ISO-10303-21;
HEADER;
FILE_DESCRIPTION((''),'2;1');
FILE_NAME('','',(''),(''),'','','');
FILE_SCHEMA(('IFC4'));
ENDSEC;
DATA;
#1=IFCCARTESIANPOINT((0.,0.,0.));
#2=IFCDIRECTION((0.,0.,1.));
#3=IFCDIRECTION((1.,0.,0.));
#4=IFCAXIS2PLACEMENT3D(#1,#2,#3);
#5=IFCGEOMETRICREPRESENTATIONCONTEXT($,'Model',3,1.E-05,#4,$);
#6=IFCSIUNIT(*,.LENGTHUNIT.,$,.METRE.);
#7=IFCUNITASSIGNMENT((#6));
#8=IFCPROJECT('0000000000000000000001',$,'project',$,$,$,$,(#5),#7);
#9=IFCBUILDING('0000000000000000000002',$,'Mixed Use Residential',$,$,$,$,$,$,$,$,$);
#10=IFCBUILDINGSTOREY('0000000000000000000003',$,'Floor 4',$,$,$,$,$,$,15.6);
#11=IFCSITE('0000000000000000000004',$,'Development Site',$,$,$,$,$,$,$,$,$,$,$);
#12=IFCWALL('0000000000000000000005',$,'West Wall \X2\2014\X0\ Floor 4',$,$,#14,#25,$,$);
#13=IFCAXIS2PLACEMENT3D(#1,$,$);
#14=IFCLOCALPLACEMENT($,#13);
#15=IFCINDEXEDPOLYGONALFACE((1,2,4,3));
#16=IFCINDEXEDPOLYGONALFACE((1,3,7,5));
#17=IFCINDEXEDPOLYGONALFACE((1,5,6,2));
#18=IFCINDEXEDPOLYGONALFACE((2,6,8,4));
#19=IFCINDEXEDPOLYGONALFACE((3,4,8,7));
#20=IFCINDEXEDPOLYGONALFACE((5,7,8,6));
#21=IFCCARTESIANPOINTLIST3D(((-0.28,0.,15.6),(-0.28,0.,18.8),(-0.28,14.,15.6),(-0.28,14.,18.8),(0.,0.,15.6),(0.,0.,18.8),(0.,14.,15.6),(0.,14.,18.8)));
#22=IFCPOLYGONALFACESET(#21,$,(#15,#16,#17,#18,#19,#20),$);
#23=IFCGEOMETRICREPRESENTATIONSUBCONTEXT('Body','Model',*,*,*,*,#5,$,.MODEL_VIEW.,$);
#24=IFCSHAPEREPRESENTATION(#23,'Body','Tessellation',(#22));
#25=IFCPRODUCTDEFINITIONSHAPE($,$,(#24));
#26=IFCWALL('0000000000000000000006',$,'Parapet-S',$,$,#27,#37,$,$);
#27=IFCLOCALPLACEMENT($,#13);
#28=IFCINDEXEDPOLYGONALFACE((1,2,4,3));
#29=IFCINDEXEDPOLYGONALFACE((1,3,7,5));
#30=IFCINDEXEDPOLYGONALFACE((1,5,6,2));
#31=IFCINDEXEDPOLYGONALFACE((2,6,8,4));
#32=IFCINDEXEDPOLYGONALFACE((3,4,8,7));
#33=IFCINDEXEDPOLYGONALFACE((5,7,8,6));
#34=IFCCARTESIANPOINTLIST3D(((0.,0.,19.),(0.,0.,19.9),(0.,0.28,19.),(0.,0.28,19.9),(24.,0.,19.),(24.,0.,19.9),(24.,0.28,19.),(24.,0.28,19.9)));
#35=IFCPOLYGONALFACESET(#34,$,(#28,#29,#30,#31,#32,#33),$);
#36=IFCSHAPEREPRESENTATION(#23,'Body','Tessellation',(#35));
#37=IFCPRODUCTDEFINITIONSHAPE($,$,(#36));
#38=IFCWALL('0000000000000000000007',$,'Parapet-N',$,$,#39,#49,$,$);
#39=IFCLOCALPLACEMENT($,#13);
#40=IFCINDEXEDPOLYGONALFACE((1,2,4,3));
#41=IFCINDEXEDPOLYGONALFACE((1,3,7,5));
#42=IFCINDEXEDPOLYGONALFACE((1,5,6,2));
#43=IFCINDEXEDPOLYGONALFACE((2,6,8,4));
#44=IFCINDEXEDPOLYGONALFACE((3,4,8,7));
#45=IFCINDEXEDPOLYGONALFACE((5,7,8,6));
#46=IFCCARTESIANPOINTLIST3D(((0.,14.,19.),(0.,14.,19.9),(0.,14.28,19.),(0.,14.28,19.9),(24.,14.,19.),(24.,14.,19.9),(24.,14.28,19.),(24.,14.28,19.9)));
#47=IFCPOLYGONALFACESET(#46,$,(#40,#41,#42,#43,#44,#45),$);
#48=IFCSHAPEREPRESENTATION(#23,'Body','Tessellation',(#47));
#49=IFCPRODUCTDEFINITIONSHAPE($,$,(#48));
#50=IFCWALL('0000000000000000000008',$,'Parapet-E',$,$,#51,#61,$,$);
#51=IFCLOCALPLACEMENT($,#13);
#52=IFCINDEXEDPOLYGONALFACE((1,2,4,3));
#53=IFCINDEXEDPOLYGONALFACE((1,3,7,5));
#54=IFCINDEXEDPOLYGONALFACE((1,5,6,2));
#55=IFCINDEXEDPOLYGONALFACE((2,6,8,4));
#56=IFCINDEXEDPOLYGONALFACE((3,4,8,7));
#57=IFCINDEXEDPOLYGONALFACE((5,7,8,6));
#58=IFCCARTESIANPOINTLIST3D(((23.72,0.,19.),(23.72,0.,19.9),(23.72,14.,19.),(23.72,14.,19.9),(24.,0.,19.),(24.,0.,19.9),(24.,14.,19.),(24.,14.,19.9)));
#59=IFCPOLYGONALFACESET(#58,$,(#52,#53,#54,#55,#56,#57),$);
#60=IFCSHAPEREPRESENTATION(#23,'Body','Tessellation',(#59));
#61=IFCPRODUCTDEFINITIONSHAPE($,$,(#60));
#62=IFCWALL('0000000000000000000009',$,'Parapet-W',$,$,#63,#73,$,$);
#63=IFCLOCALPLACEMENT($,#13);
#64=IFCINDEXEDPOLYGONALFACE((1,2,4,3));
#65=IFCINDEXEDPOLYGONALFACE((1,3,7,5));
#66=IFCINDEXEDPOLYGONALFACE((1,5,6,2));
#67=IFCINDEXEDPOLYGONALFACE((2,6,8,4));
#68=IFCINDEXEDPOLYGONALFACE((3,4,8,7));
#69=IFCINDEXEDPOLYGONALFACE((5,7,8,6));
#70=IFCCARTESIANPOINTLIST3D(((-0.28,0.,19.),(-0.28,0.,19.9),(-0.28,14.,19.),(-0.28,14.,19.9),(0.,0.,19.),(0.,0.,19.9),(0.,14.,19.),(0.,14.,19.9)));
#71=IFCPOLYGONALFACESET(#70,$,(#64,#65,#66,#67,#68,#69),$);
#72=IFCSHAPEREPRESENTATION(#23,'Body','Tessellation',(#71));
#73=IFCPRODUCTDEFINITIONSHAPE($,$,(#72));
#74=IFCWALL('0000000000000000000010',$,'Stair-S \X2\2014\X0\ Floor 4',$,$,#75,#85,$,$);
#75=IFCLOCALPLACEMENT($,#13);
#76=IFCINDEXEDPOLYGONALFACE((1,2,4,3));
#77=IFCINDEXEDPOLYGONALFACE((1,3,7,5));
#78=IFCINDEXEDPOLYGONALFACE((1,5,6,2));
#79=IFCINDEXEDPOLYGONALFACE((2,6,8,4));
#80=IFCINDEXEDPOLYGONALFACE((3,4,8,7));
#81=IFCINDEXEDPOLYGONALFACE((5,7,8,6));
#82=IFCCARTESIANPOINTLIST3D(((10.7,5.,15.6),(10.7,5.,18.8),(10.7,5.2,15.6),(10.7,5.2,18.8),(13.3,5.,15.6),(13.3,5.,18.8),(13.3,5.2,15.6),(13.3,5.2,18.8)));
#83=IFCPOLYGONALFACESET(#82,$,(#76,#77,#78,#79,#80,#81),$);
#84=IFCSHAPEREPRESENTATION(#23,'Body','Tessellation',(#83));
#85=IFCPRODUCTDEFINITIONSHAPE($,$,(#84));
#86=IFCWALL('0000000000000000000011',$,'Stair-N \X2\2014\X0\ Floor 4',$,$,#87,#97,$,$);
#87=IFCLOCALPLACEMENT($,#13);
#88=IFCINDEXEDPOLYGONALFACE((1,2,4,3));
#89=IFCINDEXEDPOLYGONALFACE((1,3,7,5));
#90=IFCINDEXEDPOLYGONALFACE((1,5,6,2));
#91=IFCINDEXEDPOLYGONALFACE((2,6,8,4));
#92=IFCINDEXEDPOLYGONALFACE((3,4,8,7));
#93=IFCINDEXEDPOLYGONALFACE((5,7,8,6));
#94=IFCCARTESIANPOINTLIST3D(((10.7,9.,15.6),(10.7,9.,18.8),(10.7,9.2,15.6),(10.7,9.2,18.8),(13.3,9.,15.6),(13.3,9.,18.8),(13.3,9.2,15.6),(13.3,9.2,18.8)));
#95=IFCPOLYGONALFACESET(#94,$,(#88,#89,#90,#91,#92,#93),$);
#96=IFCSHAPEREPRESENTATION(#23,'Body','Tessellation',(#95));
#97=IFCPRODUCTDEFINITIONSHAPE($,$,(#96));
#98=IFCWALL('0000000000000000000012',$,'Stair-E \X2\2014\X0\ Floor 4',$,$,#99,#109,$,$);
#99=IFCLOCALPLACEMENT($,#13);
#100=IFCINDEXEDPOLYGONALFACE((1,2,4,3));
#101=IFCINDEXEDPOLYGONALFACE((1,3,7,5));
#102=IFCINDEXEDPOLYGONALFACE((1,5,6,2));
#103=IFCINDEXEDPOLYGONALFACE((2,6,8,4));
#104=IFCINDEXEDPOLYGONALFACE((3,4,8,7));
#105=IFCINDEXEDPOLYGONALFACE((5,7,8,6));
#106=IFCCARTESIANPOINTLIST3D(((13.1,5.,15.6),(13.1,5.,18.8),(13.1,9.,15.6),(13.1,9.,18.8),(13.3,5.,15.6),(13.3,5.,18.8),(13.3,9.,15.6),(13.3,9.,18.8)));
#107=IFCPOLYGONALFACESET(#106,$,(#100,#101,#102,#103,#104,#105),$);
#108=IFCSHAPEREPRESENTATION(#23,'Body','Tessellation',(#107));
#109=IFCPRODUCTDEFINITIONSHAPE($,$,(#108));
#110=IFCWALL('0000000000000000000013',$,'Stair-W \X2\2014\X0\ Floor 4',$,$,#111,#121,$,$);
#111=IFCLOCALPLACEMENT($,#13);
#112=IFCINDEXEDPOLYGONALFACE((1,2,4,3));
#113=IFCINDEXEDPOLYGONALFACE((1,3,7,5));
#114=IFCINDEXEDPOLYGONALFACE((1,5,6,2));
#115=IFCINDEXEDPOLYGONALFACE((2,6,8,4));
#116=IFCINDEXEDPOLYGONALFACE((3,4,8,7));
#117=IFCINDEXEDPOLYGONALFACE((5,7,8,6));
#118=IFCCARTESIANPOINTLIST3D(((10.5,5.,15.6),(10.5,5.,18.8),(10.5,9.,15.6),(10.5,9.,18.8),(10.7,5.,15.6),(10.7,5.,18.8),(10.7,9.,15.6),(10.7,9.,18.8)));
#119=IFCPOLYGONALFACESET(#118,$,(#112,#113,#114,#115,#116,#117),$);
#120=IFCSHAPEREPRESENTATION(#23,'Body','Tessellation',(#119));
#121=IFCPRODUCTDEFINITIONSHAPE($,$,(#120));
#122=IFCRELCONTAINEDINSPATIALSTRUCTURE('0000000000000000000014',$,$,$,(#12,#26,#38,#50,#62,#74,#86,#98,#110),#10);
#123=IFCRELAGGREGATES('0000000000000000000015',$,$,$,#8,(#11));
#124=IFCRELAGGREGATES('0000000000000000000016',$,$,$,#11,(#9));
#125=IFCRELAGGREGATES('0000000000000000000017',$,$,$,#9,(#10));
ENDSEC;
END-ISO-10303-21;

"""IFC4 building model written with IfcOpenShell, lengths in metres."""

from ifc_helpers import new_model, si_unit, frame, origin_with_axes, place, context, subcontext, project, spatial, indexed_curve, outline, extrude, element, save


model = new_model("IFC4")

# Units and contexts
model_context = context("Model", 3, precision=1e-05, world=origin_with_axes())
body_context = subcontext(model_context, "Body", "Model", "MODEL_VIEW")
ifc_project = project(units=[si_unit("LENGTHUNIT", "METRE")], contexts=[model_context])

# Site, building, storey
site = spatial("IfcSite", under=ifc_project, Name="Development Site")
building = spatial("IfcBuilding", under=site, Name="Mixed Use Residential")
storey = spatial("IfcBuildingStorey", under=building, Name="Floor 4", Elevation=15.6)

# Walls
for number, where, z_axis, x_axis, name in (
    (1, (0.0, 0.0, 15.6), (0.0, 0.0, 1.0), (0.0, 1.0, 0.0), "West Wall — Floor 4"),
):
    element("IfcWall", number, at=place(None, frame(where, z_axis=z_axis, x_axis=x_axis)), inside=storey, Name=name, context=body_context, shape_type="SweptSolid", body=[
        extrude(outline(indexed_curve([(0.0, 0.0), (0.0, 0.28), (14.0, 0.28), (14.0, 0.0), (0.0, 0.0)], self_intersect=False)), origin_with_axes(), (0.0, 0.0, 1.0), 3.2),
    ])
for number, where, z_axis, x_axis, name in (
    (2, (0.0, 0.0, 19.0), (0.0, 0.0, 1.0), (1.0, 0.0, 0.0), "Parapet-S"),
    (3, (0.0, 14.0, 19.0), (0.0, 0.0, 1.0), (1.0, 0.0, 0.0), "Parapet-N"),
):
    element("IfcWall", number, at=place(None, frame(where, z_axis=z_axis, x_axis=x_axis)), inside=storey, Name=name, context=body_context, shape_type="SweptSolid", body=[
        extrude(outline(indexed_curve([(0.0, 0.0), (0.0, 0.28), (24.0, 0.28), (24.0, 0.0), (0.0, 0.0)], self_intersect=False)), origin_with_axes(), (0.0, 0.0, 1.0), 0.9),
    ])
for number, where, z_axis, x_axis, name in (
    (4, (24.0, 0.0, 19.0), (0.0, 0.0, 1.0), (0.0, 1.0, 0.0), "Parapet-E"),
    (5, (0.0, 0.0, 19.0), (0.0, 0.0, 1.0), (0.0, 1.0, 0.0), "Parapet-W"),
):
    element("IfcWall", number, at=place(None, frame(where, z_axis=z_axis, x_axis=x_axis)), inside=storey, Name=name, context=body_context, shape_type="SweptSolid", body=[
        extrude(outline(indexed_curve([(0.0, 0.0), (0.0, 0.28), (14.0, 0.28), (14.0, 0.0), (0.0, 0.0)], self_intersect=False)), origin_with_axes(), (0.0, 0.0, 1.0), 0.9),
    ])
for number, where, z_axis, x_axis, name in (
    (6, (10.7, 5.0, 15.6), (0.0, 0.0, 1.0), (1.0, 0.0, 0.0), "Stair-S — Floor 4"),
    (7, (10.7, 9.0, 15.6), (0.0, 0.0, 1.0), (1.0, 0.0, 0.0), "Stair-N — Floor 4"),
):
    element("IfcWall", number, at=place(None, frame(where, z_axis=z_axis, x_axis=x_axis)), inside=storey, Name=name, context=body_context, shape_type="SweptSolid", body=[
        extrude(outline(indexed_curve([(0.0, 0.0), (0.0, 0.2), (2.6, 0.2), (2.6, 0.0), (0.0, 0.0)], self_intersect=False)), origin_with_axes(), (0.0, 0.0, 1.0), 3.2),
    ])
for number, where, z_axis, x_axis, name in (
    (8, (13.3, 5.0, 15.6), (0.0, 0.0, 1.0), (0.0, 1.0, 0.0), "Stair-E — Floor 4"),
    (9, (10.7, 5.0, 15.6), (0.0, 0.0, 1.0), (0.0, 1.0, 0.0), "Stair-W — Floor 4"),
):
    element("IfcWall", number, at=place(None, frame(where, z_axis=z_axis, x_axis=x_axis)), inside=storey, Name=name, context=body_context, shape_type="SweptSolid", body=[
        extrude(outline(indexed_curve([(0.0, 0.0), (0.0, 0.2), (4.0, 0.2), (4.0, 0.0), (0.0, 0.0)], self_intersect=False)), origin_with_axes(), (0.0, 0.0, 1.0), 3.2),
    ])

save(model, "model.ifc")
